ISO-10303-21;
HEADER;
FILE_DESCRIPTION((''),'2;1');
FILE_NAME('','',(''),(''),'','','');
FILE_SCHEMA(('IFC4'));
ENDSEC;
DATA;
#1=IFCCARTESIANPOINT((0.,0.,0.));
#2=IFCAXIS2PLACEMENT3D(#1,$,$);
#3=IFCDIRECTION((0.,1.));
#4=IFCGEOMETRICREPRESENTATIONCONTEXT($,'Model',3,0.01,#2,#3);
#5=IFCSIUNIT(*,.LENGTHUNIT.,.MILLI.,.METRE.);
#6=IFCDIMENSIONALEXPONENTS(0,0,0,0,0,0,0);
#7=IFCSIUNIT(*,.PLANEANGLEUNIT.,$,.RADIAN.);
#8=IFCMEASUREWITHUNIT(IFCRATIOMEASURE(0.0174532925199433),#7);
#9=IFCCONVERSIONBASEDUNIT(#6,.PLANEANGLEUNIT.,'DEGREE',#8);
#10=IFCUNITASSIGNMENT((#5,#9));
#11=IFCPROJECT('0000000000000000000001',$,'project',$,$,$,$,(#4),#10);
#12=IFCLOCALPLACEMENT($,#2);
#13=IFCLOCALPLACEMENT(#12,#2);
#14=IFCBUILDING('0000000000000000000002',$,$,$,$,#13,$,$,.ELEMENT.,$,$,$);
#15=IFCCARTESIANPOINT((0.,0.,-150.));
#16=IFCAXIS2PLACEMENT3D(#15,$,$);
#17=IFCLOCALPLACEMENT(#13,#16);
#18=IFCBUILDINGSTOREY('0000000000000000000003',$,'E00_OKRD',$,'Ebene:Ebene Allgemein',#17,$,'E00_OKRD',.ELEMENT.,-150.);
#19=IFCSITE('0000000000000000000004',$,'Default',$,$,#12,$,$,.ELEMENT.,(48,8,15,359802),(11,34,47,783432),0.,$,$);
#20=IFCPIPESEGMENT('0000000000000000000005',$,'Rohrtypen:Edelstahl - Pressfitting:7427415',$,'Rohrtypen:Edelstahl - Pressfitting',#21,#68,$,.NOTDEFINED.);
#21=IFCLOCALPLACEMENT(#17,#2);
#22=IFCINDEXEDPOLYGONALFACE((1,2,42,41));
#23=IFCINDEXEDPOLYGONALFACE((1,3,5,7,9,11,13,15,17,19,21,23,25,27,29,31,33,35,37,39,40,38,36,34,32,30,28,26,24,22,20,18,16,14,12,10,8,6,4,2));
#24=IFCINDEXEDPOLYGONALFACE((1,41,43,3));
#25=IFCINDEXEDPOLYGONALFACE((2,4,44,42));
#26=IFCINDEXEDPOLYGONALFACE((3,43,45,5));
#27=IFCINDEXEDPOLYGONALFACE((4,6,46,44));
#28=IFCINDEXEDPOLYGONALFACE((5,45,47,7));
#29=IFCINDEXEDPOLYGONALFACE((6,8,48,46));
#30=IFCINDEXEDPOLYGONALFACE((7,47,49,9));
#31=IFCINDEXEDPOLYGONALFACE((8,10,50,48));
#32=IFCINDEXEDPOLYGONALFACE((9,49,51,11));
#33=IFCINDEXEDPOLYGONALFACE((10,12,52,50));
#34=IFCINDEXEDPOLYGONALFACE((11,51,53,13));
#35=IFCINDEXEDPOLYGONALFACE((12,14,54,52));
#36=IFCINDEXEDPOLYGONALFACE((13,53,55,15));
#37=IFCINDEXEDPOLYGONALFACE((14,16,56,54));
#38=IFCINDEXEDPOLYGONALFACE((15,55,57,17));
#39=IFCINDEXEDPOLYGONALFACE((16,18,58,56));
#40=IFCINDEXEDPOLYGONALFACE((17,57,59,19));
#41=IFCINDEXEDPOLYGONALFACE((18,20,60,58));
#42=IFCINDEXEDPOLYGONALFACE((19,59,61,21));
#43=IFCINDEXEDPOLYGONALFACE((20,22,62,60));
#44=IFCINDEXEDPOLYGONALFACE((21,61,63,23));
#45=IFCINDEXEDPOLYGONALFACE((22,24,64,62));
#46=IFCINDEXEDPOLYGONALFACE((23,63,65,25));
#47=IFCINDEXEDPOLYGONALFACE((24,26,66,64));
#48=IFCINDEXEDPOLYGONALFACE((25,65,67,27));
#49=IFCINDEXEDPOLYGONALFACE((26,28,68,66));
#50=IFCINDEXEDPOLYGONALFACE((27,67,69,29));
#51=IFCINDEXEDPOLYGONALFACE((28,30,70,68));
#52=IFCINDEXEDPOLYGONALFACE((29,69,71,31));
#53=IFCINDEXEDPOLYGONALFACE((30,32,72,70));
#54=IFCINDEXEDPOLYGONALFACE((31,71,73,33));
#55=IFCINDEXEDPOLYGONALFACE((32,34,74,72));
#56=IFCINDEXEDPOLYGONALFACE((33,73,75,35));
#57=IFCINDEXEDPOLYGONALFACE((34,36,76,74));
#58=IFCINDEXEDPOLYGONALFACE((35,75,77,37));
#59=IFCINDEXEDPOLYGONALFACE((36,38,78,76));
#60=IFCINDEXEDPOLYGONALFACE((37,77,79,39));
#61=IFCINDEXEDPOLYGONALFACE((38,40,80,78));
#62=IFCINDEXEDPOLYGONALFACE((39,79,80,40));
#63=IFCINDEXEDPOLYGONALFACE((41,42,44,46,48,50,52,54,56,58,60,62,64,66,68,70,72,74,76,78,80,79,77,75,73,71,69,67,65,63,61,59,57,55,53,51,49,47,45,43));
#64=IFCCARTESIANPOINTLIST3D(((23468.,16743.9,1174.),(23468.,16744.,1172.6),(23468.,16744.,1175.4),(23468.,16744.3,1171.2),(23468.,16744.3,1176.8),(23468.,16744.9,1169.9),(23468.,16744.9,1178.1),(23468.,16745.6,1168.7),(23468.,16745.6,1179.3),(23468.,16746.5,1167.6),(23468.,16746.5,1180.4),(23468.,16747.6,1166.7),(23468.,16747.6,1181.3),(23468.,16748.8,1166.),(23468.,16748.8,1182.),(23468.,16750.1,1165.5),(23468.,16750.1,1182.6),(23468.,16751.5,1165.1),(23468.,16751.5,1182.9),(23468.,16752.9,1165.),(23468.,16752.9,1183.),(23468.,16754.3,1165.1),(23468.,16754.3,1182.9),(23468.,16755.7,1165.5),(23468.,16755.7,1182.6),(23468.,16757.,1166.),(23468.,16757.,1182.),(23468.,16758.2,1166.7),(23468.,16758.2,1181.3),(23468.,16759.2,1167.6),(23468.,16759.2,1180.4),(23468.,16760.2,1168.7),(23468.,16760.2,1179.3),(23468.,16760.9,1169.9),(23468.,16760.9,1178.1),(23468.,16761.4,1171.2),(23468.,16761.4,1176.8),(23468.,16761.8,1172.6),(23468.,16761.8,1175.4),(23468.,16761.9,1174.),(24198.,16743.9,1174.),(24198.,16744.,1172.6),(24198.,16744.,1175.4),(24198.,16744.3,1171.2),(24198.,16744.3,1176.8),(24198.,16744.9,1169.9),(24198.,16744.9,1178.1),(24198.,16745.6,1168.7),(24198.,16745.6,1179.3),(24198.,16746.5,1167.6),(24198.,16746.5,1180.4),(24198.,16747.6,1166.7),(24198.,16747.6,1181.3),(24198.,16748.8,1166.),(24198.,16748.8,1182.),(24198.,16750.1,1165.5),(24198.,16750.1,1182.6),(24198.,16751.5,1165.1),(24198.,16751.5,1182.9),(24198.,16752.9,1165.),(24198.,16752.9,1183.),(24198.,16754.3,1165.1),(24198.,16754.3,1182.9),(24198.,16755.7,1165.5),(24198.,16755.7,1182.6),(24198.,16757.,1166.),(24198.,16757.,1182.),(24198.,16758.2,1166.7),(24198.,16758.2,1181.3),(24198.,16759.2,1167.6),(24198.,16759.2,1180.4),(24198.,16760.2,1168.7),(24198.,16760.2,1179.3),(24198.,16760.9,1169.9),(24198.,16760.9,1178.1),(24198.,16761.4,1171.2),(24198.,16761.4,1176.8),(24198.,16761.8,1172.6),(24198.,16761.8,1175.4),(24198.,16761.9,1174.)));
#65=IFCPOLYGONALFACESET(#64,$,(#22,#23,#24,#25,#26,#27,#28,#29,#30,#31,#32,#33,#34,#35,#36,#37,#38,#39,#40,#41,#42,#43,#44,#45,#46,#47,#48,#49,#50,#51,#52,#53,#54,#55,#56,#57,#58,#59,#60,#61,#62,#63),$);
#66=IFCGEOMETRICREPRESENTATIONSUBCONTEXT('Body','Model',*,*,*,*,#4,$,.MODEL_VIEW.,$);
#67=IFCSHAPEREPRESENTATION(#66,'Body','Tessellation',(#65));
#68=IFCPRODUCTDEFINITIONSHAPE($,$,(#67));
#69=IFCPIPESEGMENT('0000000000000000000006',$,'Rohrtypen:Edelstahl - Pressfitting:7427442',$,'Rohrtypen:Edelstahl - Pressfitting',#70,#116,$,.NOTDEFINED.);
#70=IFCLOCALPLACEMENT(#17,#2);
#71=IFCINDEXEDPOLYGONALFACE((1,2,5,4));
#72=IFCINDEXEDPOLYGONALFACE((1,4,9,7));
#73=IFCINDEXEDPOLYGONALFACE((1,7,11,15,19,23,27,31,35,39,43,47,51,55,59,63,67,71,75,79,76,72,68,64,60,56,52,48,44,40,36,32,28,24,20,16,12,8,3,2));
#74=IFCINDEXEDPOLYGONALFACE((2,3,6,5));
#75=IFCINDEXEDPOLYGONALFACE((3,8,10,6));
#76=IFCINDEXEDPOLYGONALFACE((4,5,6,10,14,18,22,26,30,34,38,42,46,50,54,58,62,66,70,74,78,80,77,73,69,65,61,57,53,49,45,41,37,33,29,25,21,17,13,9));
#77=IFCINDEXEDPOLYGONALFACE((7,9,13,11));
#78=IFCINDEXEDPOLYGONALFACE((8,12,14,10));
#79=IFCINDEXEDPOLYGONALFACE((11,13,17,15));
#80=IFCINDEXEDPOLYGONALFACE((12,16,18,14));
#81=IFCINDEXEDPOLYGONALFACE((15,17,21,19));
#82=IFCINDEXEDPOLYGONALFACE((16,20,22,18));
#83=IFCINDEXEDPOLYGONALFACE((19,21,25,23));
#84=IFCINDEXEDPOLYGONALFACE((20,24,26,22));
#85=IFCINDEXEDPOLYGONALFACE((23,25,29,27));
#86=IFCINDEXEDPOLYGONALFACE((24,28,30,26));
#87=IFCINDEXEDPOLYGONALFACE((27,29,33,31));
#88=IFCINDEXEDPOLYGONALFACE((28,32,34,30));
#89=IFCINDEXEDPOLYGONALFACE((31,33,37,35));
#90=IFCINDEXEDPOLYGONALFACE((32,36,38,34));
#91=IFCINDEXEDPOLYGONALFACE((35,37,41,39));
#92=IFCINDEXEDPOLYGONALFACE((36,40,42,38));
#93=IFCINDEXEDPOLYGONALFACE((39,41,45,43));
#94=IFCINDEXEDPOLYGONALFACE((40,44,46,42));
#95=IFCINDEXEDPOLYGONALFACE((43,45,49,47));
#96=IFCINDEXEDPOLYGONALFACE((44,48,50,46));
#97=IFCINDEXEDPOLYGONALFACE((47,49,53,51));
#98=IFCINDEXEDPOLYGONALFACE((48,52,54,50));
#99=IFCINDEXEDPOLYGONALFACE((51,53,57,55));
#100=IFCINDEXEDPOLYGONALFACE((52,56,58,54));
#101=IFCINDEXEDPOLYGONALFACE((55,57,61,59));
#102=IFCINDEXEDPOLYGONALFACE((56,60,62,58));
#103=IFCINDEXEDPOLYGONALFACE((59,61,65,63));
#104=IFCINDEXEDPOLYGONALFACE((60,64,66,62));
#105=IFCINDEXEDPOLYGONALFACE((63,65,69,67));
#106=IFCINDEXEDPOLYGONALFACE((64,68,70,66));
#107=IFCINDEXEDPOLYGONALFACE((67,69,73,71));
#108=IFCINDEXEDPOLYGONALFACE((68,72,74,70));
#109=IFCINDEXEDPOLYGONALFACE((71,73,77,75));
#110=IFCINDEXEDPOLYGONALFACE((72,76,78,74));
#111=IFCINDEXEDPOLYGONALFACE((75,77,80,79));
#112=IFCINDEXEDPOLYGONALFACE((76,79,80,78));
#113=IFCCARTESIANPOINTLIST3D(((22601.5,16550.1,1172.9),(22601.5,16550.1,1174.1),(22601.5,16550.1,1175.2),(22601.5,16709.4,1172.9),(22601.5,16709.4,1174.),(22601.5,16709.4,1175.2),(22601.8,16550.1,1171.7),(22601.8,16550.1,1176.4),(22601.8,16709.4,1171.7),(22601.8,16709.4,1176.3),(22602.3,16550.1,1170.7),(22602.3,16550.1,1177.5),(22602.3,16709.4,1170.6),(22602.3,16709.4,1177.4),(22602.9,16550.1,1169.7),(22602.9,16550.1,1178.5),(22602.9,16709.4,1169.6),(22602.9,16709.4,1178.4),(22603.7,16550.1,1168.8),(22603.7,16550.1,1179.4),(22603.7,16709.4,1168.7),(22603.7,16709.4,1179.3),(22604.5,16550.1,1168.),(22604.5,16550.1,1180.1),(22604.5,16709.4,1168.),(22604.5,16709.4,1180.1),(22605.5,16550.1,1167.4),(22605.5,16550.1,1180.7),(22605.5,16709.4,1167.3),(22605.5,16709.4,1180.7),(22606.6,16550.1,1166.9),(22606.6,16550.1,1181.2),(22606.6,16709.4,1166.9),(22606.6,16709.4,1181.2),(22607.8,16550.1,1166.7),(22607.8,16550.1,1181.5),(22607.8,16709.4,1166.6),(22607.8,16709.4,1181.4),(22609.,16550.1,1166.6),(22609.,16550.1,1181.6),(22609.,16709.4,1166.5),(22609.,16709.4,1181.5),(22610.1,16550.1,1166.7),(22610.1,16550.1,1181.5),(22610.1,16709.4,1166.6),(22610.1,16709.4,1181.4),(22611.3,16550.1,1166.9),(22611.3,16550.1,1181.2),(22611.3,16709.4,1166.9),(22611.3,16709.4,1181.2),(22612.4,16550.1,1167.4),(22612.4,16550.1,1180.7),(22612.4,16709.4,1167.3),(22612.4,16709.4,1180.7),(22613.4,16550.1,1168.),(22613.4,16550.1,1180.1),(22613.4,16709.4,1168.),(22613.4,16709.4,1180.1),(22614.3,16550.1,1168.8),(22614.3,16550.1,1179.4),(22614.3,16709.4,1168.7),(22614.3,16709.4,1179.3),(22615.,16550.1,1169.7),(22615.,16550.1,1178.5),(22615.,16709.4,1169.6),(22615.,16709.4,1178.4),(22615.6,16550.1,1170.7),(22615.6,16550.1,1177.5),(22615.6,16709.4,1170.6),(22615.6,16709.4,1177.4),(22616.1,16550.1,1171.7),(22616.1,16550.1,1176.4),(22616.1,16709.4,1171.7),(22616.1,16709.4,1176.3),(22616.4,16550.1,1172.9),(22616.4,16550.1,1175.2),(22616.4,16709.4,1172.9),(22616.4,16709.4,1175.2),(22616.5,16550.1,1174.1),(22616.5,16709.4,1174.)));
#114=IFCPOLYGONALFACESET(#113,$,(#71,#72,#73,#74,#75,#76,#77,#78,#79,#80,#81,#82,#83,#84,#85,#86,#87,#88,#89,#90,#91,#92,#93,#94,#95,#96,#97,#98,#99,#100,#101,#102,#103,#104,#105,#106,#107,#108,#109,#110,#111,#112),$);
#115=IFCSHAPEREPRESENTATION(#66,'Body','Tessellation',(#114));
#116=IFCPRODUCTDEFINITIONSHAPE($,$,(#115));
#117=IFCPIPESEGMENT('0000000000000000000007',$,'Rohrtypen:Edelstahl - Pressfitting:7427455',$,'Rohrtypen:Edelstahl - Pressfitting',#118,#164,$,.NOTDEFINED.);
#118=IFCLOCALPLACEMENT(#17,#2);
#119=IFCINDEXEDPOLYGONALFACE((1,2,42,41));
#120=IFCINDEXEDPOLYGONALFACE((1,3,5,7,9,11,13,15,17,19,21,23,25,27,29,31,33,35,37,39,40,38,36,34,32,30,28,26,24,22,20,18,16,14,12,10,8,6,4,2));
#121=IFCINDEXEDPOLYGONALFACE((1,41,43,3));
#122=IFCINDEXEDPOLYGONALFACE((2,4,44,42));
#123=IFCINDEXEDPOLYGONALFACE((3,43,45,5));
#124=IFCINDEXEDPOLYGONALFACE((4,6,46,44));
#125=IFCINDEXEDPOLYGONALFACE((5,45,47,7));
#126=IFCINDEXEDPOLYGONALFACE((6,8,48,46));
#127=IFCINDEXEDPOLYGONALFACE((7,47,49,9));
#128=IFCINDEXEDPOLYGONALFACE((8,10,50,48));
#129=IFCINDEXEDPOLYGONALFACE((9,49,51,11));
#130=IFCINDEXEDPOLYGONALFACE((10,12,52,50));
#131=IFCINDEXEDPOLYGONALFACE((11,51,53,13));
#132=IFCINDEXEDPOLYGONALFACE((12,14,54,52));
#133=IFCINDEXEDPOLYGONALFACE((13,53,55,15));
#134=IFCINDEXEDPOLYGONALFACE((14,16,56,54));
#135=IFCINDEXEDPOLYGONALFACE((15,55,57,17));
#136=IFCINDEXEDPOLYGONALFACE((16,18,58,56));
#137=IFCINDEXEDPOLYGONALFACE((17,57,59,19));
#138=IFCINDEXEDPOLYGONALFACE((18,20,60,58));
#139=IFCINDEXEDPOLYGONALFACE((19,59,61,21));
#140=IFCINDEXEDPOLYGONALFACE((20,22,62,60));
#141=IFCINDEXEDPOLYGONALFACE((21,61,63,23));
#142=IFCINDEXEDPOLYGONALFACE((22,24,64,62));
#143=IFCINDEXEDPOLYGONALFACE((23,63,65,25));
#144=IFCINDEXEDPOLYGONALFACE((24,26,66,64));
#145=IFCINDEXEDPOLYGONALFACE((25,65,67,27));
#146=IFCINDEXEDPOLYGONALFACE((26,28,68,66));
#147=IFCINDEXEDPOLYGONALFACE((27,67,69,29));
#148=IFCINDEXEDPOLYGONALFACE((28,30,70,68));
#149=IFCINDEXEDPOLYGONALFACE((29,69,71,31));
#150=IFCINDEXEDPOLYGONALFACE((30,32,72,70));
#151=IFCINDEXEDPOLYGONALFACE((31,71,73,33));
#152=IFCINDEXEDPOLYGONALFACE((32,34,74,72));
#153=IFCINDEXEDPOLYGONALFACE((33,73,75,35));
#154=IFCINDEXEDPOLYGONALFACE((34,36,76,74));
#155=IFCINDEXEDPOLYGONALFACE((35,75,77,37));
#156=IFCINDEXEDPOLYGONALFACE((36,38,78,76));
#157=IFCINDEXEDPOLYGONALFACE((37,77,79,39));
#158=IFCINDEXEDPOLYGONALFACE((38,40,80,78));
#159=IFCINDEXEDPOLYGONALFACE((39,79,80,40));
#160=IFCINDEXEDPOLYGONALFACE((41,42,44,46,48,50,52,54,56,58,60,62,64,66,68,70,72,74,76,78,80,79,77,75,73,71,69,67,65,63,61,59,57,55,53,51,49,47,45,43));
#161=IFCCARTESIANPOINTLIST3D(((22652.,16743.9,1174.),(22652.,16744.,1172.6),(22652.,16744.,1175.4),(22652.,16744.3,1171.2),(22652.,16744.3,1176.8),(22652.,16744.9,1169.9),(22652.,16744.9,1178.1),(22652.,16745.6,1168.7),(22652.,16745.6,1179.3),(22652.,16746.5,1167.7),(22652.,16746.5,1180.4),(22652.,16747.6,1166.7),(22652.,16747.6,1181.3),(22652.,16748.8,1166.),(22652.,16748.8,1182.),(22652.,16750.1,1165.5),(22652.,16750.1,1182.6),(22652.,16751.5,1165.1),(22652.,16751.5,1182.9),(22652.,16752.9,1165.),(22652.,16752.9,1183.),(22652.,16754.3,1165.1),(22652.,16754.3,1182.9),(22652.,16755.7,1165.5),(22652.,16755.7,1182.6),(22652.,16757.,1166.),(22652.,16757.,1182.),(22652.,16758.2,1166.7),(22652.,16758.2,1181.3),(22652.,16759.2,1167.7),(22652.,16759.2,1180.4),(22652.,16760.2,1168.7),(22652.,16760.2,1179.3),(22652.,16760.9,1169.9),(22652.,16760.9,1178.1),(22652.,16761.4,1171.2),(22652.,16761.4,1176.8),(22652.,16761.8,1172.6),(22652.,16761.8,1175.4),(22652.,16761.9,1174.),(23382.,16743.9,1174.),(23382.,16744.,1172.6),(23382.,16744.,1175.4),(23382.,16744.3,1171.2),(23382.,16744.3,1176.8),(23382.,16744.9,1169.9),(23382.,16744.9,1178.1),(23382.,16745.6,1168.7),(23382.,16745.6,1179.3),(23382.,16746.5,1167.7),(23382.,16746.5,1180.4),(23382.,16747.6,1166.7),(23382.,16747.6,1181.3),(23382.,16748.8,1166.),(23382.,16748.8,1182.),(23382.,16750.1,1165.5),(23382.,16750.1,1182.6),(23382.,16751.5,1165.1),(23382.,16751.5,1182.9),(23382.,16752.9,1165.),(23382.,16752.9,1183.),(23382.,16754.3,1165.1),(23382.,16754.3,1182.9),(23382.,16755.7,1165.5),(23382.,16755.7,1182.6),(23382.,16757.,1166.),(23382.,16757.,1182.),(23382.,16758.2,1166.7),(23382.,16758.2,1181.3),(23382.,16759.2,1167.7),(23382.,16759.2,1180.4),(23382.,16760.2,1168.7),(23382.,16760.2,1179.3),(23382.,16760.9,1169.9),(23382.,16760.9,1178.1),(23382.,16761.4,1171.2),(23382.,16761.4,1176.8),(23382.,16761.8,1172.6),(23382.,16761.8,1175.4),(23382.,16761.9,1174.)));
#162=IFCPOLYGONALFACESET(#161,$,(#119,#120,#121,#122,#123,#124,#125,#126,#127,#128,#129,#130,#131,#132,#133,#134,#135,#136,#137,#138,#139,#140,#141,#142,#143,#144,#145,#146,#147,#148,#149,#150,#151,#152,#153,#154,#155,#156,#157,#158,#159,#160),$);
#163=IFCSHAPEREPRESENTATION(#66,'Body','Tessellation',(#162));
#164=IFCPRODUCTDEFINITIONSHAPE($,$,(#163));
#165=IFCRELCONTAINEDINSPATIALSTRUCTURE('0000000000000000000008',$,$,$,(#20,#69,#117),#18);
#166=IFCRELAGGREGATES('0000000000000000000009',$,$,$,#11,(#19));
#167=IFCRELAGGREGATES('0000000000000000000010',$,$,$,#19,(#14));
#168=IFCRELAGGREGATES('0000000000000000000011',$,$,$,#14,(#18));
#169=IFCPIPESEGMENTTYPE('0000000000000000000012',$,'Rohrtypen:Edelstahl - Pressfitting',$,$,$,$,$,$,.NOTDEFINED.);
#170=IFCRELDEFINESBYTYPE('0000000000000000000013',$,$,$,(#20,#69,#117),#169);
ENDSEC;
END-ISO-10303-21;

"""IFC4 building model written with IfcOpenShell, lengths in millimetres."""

from ifc_helpers import new_model, entity, si_unit, converted_unit, direction, frame, origin, place, context, subcontext, project, spatial, indexed_curve, outline, extrude, type_object, element, save


model = new_model("IFC4")

# Units and contexts
model_context = context("Model", 3, precision=0.01, world=origin(), true_north=direction((0.0, 1.0)))
body_context = subcontext(model_context, "Body", "Model", "MODEL_VIEW")
ifc_project = project(units=[si_unit("LENGTHUNIT", "METRE", prefix="MILLI"), converted_unit("PLANEANGLEUNIT", "DEGREE", entity("IfcRatioMeasure", 0.0174532925199433), si_unit("PLANEANGLEUNIT", "RADIAN"), dimensions=[0, 0, 0, 0, 0, 0, 0])], contexts=[model_context])

# Site, building, storey
site_placement = place(None, origin())
site = spatial("IfcSite", under=ifc_project, at=site_placement, Name="Default", CompositionType="ELEMENT", RefLatitude=(48, 8, 15, 359802), RefLongitude=(11, 34, 47, 783432), RefElevation=0.0)
building_placement = place(site_placement, origin())
building = spatial("IfcBuilding", under=site, at=building_placement, CompositionType="ELEMENT")
storey_placement = place(building_placement, frame((0.0, 0.0, -150.0)))
storey = spatial("IfcBuildingStorey", under=building, at=storey_placement, Name="E00_OKRD", ObjectType="Ebene:Ebene Allgemein", LongName="E00_OKRD", CompositionType="ELEMENT", Elevation=-150.0)

# Pipe segments
pipe_segment_type_1 = type_object("IfcPipeSegmentType", Name="Rohrtypen:Edelstahl - Pressfitting", PredefinedType="NOTDEFINED")
pipe_segment_1_placement = place(storey_placement, origin())
element("IfcPipeSegment", 1, at=pipe_segment_1_placement, inside=storey, type_object=pipe_segment_type_1, Name="Rohrtypen:Edelstahl - Pressfitting:7427415", ObjectType="Rohrtypen:Edelstahl - Pressfitting", PredefinedType="NOTDEFINED", context=body_context, shape_type="SweptSolid", body=[
    extrude(outline(indexed_curve([(9.0, 0.0), (8.9, 1.4), (8.6, 2.8), (8.0, 4.1), (7.3, 5.3), (6.4, 6.4), (5.3, 7.3), (4.1, 8.0), (2.8, 8.6), (1.4, 8.9), (0.0, 9.0), (-1.4, 8.9), (-2.8, 8.6), (-4.1, 8.0), (-5.3, 7.3), (-6.4, 6.4), (-7.3, 5.3), (-8.0, 4.1), (-8.6, 2.8), (-8.9, 1.4), (-9.0, 0.0), (-8.9, -1.4), (-8.6, -2.8), (-8.0, -4.1), (-7.3, -5.3), (-6.4, -6.4), (-5.3, -7.3), (-4.1, -8.0), (-2.8, -8.6), (-1.4, -8.9), (0.0, -9.0), (1.4, -8.9), (2.8, -8.6), (4.1, -8.0), (5.3, -7.3), (6.4, -6.4), (7.3, -5.3), (8.0, -4.1), (8.6, -2.8), (8.9, -1.4), (9.0, 0.0)], self_intersect=False)), frame((23468.0, 16752.9, 1174.0), z_axis=(1.0, 0.0, 0.0), x_axis=(0.0, 1.0, 0.0)), (0.0, 0.0, 1.0), 730.0),
])
pipe_segment_2_placement = place(storey_placement, origin())
element("IfcPipeSegment", 2, at=pipe_segment_2_placement, inside=storey, type_object=pipe_segment_type_1, Name="Rohrtypen:Edelstahl - Pressfitting:7427442", ObjectType="Rohrtypen:Edelstahl - Pressfitting", PredefinedType="NOTDEFINED", context=body_context, shape_type="SweptSolid", body=[
    extrude(outline(indexed_curve([(7.5, 0.0), (7.4, 1.2), (7.1, 2.3), (6.7, 3.4), (6.1, 4.4), (5.3, 5.3), (4.4, 6.1), (3.4, 6.7), (2.3, 7.1), (1.2, 7.4), (0.0, 7.5), (-1.2, 7.4), (-2.3, 7.1), (-3.4, 6.7), (-4.4, 6.1), (-5.3, 5.3), (-6.1, 4.4), (-6.7, 3.4), (-7.1, 2.3), (-7.4, 1.2), (-7.5, 0.0), (-7.4, -1.2), (-7.1, -2.3), (-6.7, -3.4), (-6.1, -4.4), (-5.3, -5.3), (-4.4, -6.1), (-3.4, -6.7), (-2.3, -7.1), (-1.2, -7.4), (0.0, -7.5), (1.2, -7.4), (2.3, -7.1), (3.4, -6.7), (4.4, -6.1), (5.3, -5.3), (6.1, -4.4), (6.7, -3.4), (7.1, -2.3), (7.4, -1.2), (7.5, 0.0)], self_intersect=False)), frame((22609.0, 16550.1, 1174.1), z_axis=(0.0, 1.0, -0.0002), x_axis=(-1.0, 0.0, 0.0)), (0.0, 0.0, 1.0), 159.2),
])
pipe_segment_3_placement = place(storey_placement, origin())
element("IfcPipeSegment", 3, at=pipe_segment_3_placement, inside=storey, type_object=pipe_segment_type_1, Name="Rohrtypen:Edelstahl - Pressfitting:7427455", ObjectType="Rohrtypen:Edelstahl - Pressfitting", PredefinedType="NOTDEFINED", context=body_context, shape_type="SweptSolid", body=[
    extrude(outline(indexed_curve([(9.0, 0.0), (8.9, 1.4), (8.6, 2.8), (8.0, 4.1), (7.3, 5.3), (6.4, 6.4), (5.3, 7.3), (4.1, 8.0), (2.8, 8.6), (1.4, 8.9), (0.0, 9.0), (-1.4, 8.9), (-2.8, 8.6), (-4.1, 8.0), (-5.3, 7.3), (-6.4, 6.4), (-7.3, 5.3), (-8.0, 4.1), (-8.6, 2.8), (-8.9, 1.4), (-9.0, 0.0), (-8.9, -1.4), (-8.6, -2.8), (-8.0, -4.1), (-7.3, -5.3), (-6.4, -6.4), (-5.3, -7.3), (-4.1, -8.0), (-2.8, -8.6), (-1.4, -8.9), (0.0, -9.0), (1.4, -8.9), (2.8, -8.6), (4.1, -8.0), (5.3, -7.3), (6.4, -6.4), (7.3, -5.3), (8.0, -4.1), (8.6, -2.8), (8.9, -1.4), (9.0, 0.0)], self_intersect=False)), frame((22652.0, 16752.9, 1174.0), z_axis=(1.0, 0.0, 0.0), x_axis=(0.0, 1.0, 0.0)), (0.0, 0.0, 1.0), 730.0),
])

save(model, "model.ifc")
